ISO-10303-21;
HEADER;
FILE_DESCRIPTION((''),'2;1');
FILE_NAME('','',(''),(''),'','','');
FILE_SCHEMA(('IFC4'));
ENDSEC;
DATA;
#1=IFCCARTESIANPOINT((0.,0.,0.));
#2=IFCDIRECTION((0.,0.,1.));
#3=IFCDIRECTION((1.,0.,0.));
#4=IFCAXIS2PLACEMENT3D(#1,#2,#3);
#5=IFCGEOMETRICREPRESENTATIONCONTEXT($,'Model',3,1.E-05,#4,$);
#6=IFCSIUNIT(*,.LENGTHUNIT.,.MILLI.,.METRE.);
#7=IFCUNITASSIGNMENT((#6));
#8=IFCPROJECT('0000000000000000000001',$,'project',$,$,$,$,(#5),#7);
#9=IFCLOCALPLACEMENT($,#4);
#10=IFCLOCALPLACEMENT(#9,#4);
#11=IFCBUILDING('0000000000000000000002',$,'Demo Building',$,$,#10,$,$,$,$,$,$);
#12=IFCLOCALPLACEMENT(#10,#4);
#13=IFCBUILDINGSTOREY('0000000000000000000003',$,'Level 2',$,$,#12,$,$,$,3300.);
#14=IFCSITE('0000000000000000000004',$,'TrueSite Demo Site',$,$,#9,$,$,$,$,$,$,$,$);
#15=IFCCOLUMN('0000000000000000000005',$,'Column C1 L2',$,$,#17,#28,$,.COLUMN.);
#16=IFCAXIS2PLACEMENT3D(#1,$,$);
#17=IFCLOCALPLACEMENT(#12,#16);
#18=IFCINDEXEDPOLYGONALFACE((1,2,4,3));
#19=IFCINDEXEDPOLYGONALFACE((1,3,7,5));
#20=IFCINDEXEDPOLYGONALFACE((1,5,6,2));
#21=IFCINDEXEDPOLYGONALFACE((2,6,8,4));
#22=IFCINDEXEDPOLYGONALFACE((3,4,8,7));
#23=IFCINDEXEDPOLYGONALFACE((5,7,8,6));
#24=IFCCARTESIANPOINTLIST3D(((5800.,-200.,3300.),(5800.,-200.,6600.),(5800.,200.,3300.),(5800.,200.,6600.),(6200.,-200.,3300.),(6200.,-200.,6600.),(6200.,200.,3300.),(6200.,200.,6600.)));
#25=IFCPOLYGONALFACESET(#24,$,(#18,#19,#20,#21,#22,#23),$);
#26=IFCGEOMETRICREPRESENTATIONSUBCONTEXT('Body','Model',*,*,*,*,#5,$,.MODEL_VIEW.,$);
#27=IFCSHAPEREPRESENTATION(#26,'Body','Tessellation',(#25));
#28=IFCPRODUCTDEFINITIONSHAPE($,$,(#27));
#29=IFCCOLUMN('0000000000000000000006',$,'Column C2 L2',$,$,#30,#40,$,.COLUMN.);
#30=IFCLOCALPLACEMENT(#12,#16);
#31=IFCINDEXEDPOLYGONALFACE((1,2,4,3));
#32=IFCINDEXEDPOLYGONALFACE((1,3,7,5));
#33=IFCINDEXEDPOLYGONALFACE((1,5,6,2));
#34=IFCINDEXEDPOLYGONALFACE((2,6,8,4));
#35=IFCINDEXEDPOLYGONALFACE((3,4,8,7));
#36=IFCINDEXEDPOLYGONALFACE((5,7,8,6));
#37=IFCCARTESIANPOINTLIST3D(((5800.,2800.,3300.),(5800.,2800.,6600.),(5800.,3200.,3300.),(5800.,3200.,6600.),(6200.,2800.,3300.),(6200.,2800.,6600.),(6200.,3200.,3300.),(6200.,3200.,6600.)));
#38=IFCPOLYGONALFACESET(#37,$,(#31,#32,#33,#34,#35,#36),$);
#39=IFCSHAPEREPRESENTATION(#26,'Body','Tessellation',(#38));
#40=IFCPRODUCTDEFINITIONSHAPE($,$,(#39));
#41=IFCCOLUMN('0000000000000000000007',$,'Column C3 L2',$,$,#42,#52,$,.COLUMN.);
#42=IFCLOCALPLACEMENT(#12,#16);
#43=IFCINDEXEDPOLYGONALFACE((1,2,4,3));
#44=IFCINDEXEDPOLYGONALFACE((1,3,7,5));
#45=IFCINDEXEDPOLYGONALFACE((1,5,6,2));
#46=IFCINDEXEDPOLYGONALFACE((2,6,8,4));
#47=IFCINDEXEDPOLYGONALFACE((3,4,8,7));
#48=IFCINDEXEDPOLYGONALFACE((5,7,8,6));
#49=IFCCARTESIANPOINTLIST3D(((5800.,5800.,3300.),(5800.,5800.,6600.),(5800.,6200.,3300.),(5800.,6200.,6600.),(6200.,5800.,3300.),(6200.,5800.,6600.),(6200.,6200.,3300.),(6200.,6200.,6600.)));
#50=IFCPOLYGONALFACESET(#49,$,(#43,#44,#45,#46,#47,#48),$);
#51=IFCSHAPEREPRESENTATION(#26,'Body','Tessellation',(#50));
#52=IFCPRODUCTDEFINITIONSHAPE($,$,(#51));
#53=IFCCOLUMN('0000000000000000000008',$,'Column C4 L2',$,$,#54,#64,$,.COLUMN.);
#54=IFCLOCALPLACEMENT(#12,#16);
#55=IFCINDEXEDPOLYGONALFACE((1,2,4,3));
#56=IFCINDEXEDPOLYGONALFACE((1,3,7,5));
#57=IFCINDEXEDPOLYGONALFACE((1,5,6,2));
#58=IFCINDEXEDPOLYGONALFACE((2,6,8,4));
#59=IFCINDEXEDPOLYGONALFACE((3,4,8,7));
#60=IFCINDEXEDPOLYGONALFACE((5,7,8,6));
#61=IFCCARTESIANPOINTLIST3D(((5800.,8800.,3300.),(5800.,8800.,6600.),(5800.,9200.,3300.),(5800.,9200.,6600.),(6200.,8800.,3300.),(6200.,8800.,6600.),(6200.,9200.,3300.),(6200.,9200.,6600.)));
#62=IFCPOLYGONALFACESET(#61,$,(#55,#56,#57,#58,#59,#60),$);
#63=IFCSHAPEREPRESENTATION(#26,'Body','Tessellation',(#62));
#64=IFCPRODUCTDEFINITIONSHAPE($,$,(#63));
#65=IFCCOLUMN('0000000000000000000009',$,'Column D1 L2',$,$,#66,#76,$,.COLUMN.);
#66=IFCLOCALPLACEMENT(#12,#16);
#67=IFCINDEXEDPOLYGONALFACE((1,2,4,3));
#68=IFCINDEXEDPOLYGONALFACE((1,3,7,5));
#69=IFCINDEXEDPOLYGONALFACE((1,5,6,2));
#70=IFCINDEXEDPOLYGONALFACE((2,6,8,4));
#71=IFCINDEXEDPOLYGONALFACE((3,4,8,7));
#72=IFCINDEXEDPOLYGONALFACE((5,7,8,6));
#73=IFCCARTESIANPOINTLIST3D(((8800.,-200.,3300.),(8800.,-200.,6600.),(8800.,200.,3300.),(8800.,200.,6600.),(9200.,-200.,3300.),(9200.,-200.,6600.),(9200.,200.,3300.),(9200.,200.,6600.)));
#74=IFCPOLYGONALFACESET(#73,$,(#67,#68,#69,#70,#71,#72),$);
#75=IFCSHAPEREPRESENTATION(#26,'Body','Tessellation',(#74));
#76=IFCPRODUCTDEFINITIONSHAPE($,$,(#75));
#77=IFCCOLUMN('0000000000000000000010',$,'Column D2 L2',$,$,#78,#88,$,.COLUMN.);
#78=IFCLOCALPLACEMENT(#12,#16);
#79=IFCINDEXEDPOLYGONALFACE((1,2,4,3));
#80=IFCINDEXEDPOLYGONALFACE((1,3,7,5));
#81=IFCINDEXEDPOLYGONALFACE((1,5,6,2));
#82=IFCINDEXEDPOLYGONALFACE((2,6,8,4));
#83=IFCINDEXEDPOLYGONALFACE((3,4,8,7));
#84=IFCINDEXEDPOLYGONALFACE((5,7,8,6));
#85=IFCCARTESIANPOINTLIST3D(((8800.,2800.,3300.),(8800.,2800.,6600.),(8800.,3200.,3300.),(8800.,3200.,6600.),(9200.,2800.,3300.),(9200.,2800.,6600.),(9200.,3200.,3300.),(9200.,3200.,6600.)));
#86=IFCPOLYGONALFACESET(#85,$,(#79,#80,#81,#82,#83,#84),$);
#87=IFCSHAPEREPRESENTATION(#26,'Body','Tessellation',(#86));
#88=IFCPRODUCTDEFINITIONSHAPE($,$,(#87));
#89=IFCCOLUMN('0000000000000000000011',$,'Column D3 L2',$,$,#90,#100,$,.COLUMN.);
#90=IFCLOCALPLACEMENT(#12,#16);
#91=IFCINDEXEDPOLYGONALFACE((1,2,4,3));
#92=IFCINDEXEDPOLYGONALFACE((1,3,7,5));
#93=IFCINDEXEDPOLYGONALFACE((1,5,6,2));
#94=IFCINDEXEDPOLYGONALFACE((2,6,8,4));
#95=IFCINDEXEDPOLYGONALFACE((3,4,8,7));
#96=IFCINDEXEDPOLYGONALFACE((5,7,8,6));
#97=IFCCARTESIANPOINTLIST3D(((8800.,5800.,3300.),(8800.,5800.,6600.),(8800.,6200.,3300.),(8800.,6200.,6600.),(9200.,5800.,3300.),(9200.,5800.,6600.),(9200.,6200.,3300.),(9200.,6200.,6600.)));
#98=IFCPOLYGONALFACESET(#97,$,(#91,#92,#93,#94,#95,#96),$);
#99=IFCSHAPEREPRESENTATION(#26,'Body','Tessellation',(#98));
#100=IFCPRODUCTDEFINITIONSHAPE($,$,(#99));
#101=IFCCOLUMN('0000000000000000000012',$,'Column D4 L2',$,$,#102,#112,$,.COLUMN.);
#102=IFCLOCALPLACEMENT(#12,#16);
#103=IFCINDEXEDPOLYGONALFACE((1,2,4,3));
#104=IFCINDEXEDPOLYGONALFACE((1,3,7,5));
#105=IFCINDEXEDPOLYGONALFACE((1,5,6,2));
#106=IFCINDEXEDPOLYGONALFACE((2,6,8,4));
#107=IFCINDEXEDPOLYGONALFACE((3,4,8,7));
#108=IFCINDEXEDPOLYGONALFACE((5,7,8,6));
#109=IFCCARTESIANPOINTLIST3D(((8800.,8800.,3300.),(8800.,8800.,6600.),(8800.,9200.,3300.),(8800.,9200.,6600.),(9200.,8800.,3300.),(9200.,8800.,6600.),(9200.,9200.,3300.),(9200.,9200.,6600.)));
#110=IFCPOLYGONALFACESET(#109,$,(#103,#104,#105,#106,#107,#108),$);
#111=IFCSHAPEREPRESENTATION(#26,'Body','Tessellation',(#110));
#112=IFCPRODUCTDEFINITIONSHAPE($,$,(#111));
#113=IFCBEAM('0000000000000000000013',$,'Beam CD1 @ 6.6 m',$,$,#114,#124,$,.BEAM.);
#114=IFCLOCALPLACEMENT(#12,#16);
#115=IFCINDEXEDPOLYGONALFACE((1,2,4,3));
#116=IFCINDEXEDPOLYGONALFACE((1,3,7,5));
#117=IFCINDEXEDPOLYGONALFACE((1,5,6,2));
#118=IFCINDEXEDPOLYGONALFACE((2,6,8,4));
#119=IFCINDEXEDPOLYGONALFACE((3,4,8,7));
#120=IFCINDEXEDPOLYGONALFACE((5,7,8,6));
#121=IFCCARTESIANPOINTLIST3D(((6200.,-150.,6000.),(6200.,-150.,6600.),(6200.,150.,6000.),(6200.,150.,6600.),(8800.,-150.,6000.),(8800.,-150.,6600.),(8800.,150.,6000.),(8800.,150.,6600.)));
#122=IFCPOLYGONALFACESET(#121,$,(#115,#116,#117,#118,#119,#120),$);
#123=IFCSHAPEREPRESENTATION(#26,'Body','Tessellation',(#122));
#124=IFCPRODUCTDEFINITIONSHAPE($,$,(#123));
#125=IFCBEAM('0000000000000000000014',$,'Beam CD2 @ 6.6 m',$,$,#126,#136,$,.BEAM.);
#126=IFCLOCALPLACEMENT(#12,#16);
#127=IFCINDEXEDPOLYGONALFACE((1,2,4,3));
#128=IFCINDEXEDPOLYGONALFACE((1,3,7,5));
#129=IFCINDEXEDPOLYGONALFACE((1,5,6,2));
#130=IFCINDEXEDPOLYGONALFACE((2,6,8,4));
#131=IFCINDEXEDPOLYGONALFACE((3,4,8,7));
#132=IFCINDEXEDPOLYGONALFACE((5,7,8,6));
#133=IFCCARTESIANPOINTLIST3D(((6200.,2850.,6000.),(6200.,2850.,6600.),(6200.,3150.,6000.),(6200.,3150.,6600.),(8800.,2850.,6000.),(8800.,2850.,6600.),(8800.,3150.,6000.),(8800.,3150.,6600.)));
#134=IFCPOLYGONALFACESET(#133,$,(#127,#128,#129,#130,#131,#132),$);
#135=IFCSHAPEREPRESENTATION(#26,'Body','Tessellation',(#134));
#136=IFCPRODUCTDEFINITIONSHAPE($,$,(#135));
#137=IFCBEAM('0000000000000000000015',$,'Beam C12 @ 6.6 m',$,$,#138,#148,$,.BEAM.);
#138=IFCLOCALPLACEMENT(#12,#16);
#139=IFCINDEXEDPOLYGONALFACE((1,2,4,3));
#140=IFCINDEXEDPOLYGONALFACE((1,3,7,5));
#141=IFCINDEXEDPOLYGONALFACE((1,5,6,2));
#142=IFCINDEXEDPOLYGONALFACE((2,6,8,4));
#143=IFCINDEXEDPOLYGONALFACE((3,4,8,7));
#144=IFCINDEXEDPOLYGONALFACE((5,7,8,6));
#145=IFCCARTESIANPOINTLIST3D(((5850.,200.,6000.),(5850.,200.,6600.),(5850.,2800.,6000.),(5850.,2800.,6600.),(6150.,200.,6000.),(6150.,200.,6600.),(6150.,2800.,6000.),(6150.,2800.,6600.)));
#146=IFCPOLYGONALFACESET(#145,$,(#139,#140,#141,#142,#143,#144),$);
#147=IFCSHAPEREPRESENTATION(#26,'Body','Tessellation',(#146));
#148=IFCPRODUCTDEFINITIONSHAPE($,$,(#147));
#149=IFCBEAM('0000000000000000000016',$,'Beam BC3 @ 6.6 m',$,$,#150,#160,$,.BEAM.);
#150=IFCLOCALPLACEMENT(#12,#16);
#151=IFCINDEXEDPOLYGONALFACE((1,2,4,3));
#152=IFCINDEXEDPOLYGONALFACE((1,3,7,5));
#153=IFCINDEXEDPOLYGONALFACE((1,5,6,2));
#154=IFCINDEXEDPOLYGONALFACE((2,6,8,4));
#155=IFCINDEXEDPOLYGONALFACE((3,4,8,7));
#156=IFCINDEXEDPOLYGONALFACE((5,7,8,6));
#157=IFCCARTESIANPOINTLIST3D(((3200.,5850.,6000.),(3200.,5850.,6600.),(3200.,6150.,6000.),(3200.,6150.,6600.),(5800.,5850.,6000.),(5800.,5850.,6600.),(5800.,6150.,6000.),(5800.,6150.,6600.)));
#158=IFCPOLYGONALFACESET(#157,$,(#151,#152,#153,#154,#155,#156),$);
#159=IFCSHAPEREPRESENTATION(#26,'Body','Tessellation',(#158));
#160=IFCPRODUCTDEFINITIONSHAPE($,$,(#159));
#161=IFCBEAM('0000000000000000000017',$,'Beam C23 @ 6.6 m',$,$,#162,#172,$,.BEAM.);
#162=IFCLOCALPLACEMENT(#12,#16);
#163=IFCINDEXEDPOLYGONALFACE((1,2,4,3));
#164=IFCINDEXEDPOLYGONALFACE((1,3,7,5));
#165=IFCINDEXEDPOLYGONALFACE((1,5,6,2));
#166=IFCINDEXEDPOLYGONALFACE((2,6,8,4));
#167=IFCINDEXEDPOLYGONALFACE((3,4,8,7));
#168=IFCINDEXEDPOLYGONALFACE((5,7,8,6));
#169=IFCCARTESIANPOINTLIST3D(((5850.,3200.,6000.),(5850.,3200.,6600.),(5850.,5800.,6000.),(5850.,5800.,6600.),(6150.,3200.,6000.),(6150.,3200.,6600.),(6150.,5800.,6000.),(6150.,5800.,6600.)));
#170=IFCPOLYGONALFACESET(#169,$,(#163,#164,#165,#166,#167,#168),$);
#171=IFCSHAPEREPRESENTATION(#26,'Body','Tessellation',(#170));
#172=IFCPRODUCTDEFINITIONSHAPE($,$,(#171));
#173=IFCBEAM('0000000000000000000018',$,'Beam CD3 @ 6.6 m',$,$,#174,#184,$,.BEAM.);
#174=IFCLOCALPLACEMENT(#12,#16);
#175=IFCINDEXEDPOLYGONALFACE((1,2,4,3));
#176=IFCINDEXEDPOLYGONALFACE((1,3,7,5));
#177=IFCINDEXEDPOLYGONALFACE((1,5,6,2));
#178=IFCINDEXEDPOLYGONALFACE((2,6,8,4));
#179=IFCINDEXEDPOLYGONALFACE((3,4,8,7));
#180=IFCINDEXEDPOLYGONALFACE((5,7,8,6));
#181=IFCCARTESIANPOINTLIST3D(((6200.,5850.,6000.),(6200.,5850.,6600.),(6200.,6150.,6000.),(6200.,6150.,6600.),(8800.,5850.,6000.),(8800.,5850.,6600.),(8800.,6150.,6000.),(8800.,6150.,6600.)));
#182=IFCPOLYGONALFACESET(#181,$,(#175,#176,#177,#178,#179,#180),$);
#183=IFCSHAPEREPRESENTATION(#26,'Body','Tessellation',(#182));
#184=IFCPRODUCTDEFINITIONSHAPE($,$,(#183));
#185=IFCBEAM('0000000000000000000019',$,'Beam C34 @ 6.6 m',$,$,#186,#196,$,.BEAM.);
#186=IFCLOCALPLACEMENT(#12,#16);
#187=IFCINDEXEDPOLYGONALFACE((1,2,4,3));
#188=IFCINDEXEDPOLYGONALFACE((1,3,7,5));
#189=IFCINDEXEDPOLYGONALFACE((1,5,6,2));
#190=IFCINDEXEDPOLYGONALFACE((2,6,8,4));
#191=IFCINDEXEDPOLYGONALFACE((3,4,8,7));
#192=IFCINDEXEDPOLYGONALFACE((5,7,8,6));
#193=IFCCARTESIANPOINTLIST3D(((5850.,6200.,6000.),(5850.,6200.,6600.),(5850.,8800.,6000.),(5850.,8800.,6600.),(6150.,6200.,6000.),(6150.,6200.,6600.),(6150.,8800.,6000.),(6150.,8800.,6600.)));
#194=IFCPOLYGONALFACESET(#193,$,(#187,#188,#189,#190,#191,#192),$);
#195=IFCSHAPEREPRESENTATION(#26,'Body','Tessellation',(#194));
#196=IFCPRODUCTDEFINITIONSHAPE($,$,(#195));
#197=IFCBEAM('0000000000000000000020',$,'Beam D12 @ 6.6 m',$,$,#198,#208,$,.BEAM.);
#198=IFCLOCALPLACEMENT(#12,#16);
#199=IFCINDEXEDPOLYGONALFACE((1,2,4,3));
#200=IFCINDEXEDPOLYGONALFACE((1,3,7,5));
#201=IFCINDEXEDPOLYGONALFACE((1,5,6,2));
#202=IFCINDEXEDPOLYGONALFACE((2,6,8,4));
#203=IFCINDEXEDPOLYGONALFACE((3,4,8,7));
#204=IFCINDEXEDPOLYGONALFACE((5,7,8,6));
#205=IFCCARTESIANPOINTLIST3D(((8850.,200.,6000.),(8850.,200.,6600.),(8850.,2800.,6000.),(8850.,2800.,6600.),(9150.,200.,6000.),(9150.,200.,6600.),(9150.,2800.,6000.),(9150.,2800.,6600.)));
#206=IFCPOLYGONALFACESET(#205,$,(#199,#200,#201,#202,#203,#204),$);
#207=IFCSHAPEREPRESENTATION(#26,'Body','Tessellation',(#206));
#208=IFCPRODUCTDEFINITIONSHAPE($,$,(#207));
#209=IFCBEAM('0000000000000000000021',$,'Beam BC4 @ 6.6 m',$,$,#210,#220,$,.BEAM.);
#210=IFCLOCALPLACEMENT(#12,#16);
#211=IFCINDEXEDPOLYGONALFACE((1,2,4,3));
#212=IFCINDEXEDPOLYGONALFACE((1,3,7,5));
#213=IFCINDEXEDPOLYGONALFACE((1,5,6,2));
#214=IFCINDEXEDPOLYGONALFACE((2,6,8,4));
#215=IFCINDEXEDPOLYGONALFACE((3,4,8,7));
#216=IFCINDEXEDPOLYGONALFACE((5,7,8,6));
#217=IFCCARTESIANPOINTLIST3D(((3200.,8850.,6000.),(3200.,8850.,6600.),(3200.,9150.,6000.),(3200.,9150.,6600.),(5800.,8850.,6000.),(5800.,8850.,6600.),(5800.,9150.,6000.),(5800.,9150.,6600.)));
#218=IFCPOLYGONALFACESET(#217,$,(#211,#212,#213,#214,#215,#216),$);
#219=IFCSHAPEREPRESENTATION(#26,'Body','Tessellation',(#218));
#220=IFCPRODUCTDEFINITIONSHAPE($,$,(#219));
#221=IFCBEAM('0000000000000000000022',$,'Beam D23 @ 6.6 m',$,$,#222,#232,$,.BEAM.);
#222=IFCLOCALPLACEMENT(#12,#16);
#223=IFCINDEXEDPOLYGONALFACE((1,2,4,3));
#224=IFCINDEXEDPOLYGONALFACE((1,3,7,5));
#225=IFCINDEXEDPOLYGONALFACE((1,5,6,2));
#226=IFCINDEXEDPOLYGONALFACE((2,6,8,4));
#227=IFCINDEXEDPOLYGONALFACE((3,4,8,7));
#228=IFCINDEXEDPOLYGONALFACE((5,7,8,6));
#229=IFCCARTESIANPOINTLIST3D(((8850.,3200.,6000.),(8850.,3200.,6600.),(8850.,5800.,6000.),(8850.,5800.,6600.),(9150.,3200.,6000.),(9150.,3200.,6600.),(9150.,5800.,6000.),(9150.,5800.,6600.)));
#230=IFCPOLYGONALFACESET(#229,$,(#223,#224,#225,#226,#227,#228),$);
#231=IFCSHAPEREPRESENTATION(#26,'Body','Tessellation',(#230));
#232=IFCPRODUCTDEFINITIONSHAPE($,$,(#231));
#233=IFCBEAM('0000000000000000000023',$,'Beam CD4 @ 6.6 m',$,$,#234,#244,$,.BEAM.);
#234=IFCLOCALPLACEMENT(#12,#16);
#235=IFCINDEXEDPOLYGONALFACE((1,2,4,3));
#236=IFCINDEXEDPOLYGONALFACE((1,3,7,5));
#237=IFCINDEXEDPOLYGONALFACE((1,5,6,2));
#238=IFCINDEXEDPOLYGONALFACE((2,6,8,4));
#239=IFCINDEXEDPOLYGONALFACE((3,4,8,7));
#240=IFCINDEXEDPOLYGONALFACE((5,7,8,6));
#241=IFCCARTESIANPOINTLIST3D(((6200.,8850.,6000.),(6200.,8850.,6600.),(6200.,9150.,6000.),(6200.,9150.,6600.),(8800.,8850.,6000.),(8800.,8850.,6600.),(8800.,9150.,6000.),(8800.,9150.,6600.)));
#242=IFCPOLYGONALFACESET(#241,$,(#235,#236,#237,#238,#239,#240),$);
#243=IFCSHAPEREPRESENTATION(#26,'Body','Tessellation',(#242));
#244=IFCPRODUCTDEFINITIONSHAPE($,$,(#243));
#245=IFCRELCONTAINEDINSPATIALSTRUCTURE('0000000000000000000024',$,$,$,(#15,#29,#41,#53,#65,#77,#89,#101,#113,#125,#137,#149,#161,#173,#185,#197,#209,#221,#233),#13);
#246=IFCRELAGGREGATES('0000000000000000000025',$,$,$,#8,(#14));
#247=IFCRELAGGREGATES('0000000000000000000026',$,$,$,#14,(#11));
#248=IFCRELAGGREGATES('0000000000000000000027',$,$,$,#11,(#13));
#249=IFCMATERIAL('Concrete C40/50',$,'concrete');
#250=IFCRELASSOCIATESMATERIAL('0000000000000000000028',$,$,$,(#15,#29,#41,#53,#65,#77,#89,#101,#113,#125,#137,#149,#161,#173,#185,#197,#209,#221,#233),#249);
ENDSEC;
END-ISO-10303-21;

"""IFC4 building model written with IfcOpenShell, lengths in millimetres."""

from ifc_helpers import new_model, si_unit, frame, origin_with_axes, place, context, subcontext, project, spatial, rectangle, extrude, material, element, save


model = new_model("IFC4")

# Units and contexts
model_context = context("Model", 3, precision=1e-05, world=origin_with_axes())
body_context = subcontext(model_context, "Body", "Model", "MODEL_VIEW")
ifc_project = project(units=[si_unit("LENGTHUNIT", "METRE", prefix="MILLI")], contexts=[model_context])

# Site, building, storey
site_placement = place(None, origin_with_axes())
site = spatial("IfcSite", under=ifc_project, at=site_placement, Name="TrueSite Demo Site")
building_placement = place(site_placement, origin_with_axes())
building = spatial("IfcBuilding", under=site, at=building_placement, Name="Demo Building")
storey_placement = place(building_placement, origin_with_axes())
storey = spatial("IfcBuildingStorey", under=building, at=storey_placement, Name="Level 2", Elevation=3300.0)

# Columns
ifc_material_1 = material(Name="Concrete C40/50", Category="concrete")
for number, where, z_axis, x_axis, name in (
    (1, (6000.0, 0.0, 3300.0), (0.0, 0.0, 1.0), (1.0, 0.0, 0.0), "Column C1 L2"),
    (2, (6000.0, 3000.0, 3300.0), (0.0, 0.0, 1.0), (1.0, 0.0, 0.0), "Column C2 L2"),
    (3, (6000.0, 6000.0, 3300.0), (0.0, 0.0, 1.0), (1.0, 0.0, 0.0), "Column C3 L2"),
    (4, (6000.0, 9000.0, 3300.0), (0.0, 0.0, 1.0), (1.0, 0.0, 0.0), "Column C4 L2"),
    (5, (9000.0, 0.0, 3300.0), (0.0, 0.0, 1.0), (1.0, 0.0, 0.0), "Column D1 L2"),
    (6, (9000.0, 3000.0, 3300.0), (0.0, 0.0, 1.0), (1.0, 0.0, 0.0), "Column D2 L2"),
    (7, (9000.0, 6000.0, 3300.0), (0.0, 0.0, 1.0), (1.0, 0.0, 0.0), "Column D3 L2"),
    (8, (9000.0, 9000.0, 3300.0), (0.0, 0.0, 1.0), (1.0, 0.0, 0.0), "Column D4 L2"),
):
    element("IfcColumn", number, at=place(storey_placement, frame(where, z_axis=z_axis, x_axis=x_axis)), inside=storey, material=ifc_material_1, Name=name, PredefinedType="COLUMN", context=body_context, shape_type="SweptSolid", body=[
        extrude(rectangle(XDim=400.0, YDim=400.0), origin_with_axes(), (0.0, 0.0, 1.0), 3300.0),
    ])

# Beams
for number, where, z_axis, x_axis, name in (
    (9, (6200.0, 0.0, 6300.0), (1.0, 0.0, 0.0), (0.0, 1.0, 0.0), "Beam CD1 @ 6.6 m"),
    (10, (6200.0, 3000.0, 6300.0), (1.0, 0.0, 0.0), (0.0, 1.0, 0.0), "Beam CD2 @ 6.6 m"),
):
    element("IfcBeam", number, at=place(storey_placement, frame(where, z_axis=z_axis, x_axis=x_axis)), inside=storey, material=ifc_material_1, Name=name, PredefinedType="BEAM", context=body_context, shape_type="SweptSolid", body=[
        extrude(rectangle(XDim=300.0, YDim=600.0), origin_with_axes(), (0.0, 0.0, 1.0), 2600.0),
    ])
for number, where, z_axis, x_axis, name in (
    (11, (6000.0, 200.0, 6300.0), (0.0, 1.0, 0.0), (1.0, 0.0, 0.0), "Beam C12 @ 6.6 m"),
    (12, (3200.0, 6000.0, 6300.0), (1.0, 0.0, 0.0), (0.0, 1.0, 0.0), "Beam BC3 @ 6.6 m"),
    (13, (6000.0, 3200.0, 6300.0), (0.0, 1.0, 0.0), (1.0, 0.0, 0.0), "Beam C23 @ 6.6 m"),
):
    element("IfcBeam", number, at=place(storey_placement, frame(where, z_axis=z_axis, x_axis=x_axis)), inside=storey, material=ifc_material_1, Name=name, PredefinedType="BEAM", context=body_context, shape_type="SweptSolid", body=[
        extrude(rectangle(XDim=300.0, YDim=600.0), origin_with_axes(), (0.0, 0.0, 1.0), 2600.0),
    ])
for number, where, z_axis, x_axis, name in (
    (14, (6200.0, 6000.0, 6300.0), (1.0, 0.0, 0.0), (0.0, 1.0, 0.0), "Beam CD3 @ 6.6 m"),
    (15, (6000.0, 6200.0, 6300.0), (0.0, 1.0, 0.0), (1.0, 0.0, 0.0), "Beam C34 @ 6.6 m"),
):
    element("IfcBeam", number, at=place(storey_placement, frame(where, z_axis=z_axis, x_axis=x_axis)), inside=storey, material=ifc_material_1, Name=name, PredefinedType="BEAM", context=body_context, shape_type="SweptSolid", body=[
        extrude(rectangle(XDim=300.0, YDim=600.0), origin_with_axes(), (0.0, 0.0, 1.0), 2600.0),
    ])
for number, where, z_axis, x_axis, name in (
    (16, (9000.0, 200.0, 6300.0), (0.0, 1.0, 0.0), (1.0, 0.0, 0.0), "Beam D12 @ 6.6 m"),
    (17, (3200.0, 9000.0, 6300.0), (1.0, 0.0, 0.0), (0.0, 1.0, 0.0), "Beam BC4 @ 6.6 m"),
    (18, (9000.0, 3200.0, 6300.0), (0.0, 1.0, 0.0), (1.0, 0.0, 0.0), "Beam D23 @ 6.6 m"),
):
    element("IfcBeam", number, at=place(storey_placement, frame(where, z_axis=z_axis, x_axis=x_axis)), inside=storey, material=ifc_material_1, Name=name, PredefinedType="BEAM", context=body_context, shape_type="SweptSolid", body=[
        extrude(rectangle(XDim=300.0, YDim=600.0), origin_with_axes(), (0.0, 0.0, 1.0), 2600.0),
    ])
for number, where, z_axis, x_axis, name in (
    (19, (6200.0, 9000.0, 6300.0), (1.0, 0.0, 0.0), (0.0, 1.0, 0.0), "Beam CD4 @ 6.6 m"),
):
    element("IfcBeam", number, at=place(storey_placement, frame(where, z_axis=z_axis, x_axis=x_axis)), inside=storey, material=ifc_material_1, Name=name, PredefinedType="BEAM", context=body_context, shape_type="SweptSolid", body=[
        extrude(rectangle(XDim=300.0, YDim=600.0), origin_with_axes(), (0.0, 0.0, 1.0), 2600.0),
    ])

save(model, "model.ifc")
